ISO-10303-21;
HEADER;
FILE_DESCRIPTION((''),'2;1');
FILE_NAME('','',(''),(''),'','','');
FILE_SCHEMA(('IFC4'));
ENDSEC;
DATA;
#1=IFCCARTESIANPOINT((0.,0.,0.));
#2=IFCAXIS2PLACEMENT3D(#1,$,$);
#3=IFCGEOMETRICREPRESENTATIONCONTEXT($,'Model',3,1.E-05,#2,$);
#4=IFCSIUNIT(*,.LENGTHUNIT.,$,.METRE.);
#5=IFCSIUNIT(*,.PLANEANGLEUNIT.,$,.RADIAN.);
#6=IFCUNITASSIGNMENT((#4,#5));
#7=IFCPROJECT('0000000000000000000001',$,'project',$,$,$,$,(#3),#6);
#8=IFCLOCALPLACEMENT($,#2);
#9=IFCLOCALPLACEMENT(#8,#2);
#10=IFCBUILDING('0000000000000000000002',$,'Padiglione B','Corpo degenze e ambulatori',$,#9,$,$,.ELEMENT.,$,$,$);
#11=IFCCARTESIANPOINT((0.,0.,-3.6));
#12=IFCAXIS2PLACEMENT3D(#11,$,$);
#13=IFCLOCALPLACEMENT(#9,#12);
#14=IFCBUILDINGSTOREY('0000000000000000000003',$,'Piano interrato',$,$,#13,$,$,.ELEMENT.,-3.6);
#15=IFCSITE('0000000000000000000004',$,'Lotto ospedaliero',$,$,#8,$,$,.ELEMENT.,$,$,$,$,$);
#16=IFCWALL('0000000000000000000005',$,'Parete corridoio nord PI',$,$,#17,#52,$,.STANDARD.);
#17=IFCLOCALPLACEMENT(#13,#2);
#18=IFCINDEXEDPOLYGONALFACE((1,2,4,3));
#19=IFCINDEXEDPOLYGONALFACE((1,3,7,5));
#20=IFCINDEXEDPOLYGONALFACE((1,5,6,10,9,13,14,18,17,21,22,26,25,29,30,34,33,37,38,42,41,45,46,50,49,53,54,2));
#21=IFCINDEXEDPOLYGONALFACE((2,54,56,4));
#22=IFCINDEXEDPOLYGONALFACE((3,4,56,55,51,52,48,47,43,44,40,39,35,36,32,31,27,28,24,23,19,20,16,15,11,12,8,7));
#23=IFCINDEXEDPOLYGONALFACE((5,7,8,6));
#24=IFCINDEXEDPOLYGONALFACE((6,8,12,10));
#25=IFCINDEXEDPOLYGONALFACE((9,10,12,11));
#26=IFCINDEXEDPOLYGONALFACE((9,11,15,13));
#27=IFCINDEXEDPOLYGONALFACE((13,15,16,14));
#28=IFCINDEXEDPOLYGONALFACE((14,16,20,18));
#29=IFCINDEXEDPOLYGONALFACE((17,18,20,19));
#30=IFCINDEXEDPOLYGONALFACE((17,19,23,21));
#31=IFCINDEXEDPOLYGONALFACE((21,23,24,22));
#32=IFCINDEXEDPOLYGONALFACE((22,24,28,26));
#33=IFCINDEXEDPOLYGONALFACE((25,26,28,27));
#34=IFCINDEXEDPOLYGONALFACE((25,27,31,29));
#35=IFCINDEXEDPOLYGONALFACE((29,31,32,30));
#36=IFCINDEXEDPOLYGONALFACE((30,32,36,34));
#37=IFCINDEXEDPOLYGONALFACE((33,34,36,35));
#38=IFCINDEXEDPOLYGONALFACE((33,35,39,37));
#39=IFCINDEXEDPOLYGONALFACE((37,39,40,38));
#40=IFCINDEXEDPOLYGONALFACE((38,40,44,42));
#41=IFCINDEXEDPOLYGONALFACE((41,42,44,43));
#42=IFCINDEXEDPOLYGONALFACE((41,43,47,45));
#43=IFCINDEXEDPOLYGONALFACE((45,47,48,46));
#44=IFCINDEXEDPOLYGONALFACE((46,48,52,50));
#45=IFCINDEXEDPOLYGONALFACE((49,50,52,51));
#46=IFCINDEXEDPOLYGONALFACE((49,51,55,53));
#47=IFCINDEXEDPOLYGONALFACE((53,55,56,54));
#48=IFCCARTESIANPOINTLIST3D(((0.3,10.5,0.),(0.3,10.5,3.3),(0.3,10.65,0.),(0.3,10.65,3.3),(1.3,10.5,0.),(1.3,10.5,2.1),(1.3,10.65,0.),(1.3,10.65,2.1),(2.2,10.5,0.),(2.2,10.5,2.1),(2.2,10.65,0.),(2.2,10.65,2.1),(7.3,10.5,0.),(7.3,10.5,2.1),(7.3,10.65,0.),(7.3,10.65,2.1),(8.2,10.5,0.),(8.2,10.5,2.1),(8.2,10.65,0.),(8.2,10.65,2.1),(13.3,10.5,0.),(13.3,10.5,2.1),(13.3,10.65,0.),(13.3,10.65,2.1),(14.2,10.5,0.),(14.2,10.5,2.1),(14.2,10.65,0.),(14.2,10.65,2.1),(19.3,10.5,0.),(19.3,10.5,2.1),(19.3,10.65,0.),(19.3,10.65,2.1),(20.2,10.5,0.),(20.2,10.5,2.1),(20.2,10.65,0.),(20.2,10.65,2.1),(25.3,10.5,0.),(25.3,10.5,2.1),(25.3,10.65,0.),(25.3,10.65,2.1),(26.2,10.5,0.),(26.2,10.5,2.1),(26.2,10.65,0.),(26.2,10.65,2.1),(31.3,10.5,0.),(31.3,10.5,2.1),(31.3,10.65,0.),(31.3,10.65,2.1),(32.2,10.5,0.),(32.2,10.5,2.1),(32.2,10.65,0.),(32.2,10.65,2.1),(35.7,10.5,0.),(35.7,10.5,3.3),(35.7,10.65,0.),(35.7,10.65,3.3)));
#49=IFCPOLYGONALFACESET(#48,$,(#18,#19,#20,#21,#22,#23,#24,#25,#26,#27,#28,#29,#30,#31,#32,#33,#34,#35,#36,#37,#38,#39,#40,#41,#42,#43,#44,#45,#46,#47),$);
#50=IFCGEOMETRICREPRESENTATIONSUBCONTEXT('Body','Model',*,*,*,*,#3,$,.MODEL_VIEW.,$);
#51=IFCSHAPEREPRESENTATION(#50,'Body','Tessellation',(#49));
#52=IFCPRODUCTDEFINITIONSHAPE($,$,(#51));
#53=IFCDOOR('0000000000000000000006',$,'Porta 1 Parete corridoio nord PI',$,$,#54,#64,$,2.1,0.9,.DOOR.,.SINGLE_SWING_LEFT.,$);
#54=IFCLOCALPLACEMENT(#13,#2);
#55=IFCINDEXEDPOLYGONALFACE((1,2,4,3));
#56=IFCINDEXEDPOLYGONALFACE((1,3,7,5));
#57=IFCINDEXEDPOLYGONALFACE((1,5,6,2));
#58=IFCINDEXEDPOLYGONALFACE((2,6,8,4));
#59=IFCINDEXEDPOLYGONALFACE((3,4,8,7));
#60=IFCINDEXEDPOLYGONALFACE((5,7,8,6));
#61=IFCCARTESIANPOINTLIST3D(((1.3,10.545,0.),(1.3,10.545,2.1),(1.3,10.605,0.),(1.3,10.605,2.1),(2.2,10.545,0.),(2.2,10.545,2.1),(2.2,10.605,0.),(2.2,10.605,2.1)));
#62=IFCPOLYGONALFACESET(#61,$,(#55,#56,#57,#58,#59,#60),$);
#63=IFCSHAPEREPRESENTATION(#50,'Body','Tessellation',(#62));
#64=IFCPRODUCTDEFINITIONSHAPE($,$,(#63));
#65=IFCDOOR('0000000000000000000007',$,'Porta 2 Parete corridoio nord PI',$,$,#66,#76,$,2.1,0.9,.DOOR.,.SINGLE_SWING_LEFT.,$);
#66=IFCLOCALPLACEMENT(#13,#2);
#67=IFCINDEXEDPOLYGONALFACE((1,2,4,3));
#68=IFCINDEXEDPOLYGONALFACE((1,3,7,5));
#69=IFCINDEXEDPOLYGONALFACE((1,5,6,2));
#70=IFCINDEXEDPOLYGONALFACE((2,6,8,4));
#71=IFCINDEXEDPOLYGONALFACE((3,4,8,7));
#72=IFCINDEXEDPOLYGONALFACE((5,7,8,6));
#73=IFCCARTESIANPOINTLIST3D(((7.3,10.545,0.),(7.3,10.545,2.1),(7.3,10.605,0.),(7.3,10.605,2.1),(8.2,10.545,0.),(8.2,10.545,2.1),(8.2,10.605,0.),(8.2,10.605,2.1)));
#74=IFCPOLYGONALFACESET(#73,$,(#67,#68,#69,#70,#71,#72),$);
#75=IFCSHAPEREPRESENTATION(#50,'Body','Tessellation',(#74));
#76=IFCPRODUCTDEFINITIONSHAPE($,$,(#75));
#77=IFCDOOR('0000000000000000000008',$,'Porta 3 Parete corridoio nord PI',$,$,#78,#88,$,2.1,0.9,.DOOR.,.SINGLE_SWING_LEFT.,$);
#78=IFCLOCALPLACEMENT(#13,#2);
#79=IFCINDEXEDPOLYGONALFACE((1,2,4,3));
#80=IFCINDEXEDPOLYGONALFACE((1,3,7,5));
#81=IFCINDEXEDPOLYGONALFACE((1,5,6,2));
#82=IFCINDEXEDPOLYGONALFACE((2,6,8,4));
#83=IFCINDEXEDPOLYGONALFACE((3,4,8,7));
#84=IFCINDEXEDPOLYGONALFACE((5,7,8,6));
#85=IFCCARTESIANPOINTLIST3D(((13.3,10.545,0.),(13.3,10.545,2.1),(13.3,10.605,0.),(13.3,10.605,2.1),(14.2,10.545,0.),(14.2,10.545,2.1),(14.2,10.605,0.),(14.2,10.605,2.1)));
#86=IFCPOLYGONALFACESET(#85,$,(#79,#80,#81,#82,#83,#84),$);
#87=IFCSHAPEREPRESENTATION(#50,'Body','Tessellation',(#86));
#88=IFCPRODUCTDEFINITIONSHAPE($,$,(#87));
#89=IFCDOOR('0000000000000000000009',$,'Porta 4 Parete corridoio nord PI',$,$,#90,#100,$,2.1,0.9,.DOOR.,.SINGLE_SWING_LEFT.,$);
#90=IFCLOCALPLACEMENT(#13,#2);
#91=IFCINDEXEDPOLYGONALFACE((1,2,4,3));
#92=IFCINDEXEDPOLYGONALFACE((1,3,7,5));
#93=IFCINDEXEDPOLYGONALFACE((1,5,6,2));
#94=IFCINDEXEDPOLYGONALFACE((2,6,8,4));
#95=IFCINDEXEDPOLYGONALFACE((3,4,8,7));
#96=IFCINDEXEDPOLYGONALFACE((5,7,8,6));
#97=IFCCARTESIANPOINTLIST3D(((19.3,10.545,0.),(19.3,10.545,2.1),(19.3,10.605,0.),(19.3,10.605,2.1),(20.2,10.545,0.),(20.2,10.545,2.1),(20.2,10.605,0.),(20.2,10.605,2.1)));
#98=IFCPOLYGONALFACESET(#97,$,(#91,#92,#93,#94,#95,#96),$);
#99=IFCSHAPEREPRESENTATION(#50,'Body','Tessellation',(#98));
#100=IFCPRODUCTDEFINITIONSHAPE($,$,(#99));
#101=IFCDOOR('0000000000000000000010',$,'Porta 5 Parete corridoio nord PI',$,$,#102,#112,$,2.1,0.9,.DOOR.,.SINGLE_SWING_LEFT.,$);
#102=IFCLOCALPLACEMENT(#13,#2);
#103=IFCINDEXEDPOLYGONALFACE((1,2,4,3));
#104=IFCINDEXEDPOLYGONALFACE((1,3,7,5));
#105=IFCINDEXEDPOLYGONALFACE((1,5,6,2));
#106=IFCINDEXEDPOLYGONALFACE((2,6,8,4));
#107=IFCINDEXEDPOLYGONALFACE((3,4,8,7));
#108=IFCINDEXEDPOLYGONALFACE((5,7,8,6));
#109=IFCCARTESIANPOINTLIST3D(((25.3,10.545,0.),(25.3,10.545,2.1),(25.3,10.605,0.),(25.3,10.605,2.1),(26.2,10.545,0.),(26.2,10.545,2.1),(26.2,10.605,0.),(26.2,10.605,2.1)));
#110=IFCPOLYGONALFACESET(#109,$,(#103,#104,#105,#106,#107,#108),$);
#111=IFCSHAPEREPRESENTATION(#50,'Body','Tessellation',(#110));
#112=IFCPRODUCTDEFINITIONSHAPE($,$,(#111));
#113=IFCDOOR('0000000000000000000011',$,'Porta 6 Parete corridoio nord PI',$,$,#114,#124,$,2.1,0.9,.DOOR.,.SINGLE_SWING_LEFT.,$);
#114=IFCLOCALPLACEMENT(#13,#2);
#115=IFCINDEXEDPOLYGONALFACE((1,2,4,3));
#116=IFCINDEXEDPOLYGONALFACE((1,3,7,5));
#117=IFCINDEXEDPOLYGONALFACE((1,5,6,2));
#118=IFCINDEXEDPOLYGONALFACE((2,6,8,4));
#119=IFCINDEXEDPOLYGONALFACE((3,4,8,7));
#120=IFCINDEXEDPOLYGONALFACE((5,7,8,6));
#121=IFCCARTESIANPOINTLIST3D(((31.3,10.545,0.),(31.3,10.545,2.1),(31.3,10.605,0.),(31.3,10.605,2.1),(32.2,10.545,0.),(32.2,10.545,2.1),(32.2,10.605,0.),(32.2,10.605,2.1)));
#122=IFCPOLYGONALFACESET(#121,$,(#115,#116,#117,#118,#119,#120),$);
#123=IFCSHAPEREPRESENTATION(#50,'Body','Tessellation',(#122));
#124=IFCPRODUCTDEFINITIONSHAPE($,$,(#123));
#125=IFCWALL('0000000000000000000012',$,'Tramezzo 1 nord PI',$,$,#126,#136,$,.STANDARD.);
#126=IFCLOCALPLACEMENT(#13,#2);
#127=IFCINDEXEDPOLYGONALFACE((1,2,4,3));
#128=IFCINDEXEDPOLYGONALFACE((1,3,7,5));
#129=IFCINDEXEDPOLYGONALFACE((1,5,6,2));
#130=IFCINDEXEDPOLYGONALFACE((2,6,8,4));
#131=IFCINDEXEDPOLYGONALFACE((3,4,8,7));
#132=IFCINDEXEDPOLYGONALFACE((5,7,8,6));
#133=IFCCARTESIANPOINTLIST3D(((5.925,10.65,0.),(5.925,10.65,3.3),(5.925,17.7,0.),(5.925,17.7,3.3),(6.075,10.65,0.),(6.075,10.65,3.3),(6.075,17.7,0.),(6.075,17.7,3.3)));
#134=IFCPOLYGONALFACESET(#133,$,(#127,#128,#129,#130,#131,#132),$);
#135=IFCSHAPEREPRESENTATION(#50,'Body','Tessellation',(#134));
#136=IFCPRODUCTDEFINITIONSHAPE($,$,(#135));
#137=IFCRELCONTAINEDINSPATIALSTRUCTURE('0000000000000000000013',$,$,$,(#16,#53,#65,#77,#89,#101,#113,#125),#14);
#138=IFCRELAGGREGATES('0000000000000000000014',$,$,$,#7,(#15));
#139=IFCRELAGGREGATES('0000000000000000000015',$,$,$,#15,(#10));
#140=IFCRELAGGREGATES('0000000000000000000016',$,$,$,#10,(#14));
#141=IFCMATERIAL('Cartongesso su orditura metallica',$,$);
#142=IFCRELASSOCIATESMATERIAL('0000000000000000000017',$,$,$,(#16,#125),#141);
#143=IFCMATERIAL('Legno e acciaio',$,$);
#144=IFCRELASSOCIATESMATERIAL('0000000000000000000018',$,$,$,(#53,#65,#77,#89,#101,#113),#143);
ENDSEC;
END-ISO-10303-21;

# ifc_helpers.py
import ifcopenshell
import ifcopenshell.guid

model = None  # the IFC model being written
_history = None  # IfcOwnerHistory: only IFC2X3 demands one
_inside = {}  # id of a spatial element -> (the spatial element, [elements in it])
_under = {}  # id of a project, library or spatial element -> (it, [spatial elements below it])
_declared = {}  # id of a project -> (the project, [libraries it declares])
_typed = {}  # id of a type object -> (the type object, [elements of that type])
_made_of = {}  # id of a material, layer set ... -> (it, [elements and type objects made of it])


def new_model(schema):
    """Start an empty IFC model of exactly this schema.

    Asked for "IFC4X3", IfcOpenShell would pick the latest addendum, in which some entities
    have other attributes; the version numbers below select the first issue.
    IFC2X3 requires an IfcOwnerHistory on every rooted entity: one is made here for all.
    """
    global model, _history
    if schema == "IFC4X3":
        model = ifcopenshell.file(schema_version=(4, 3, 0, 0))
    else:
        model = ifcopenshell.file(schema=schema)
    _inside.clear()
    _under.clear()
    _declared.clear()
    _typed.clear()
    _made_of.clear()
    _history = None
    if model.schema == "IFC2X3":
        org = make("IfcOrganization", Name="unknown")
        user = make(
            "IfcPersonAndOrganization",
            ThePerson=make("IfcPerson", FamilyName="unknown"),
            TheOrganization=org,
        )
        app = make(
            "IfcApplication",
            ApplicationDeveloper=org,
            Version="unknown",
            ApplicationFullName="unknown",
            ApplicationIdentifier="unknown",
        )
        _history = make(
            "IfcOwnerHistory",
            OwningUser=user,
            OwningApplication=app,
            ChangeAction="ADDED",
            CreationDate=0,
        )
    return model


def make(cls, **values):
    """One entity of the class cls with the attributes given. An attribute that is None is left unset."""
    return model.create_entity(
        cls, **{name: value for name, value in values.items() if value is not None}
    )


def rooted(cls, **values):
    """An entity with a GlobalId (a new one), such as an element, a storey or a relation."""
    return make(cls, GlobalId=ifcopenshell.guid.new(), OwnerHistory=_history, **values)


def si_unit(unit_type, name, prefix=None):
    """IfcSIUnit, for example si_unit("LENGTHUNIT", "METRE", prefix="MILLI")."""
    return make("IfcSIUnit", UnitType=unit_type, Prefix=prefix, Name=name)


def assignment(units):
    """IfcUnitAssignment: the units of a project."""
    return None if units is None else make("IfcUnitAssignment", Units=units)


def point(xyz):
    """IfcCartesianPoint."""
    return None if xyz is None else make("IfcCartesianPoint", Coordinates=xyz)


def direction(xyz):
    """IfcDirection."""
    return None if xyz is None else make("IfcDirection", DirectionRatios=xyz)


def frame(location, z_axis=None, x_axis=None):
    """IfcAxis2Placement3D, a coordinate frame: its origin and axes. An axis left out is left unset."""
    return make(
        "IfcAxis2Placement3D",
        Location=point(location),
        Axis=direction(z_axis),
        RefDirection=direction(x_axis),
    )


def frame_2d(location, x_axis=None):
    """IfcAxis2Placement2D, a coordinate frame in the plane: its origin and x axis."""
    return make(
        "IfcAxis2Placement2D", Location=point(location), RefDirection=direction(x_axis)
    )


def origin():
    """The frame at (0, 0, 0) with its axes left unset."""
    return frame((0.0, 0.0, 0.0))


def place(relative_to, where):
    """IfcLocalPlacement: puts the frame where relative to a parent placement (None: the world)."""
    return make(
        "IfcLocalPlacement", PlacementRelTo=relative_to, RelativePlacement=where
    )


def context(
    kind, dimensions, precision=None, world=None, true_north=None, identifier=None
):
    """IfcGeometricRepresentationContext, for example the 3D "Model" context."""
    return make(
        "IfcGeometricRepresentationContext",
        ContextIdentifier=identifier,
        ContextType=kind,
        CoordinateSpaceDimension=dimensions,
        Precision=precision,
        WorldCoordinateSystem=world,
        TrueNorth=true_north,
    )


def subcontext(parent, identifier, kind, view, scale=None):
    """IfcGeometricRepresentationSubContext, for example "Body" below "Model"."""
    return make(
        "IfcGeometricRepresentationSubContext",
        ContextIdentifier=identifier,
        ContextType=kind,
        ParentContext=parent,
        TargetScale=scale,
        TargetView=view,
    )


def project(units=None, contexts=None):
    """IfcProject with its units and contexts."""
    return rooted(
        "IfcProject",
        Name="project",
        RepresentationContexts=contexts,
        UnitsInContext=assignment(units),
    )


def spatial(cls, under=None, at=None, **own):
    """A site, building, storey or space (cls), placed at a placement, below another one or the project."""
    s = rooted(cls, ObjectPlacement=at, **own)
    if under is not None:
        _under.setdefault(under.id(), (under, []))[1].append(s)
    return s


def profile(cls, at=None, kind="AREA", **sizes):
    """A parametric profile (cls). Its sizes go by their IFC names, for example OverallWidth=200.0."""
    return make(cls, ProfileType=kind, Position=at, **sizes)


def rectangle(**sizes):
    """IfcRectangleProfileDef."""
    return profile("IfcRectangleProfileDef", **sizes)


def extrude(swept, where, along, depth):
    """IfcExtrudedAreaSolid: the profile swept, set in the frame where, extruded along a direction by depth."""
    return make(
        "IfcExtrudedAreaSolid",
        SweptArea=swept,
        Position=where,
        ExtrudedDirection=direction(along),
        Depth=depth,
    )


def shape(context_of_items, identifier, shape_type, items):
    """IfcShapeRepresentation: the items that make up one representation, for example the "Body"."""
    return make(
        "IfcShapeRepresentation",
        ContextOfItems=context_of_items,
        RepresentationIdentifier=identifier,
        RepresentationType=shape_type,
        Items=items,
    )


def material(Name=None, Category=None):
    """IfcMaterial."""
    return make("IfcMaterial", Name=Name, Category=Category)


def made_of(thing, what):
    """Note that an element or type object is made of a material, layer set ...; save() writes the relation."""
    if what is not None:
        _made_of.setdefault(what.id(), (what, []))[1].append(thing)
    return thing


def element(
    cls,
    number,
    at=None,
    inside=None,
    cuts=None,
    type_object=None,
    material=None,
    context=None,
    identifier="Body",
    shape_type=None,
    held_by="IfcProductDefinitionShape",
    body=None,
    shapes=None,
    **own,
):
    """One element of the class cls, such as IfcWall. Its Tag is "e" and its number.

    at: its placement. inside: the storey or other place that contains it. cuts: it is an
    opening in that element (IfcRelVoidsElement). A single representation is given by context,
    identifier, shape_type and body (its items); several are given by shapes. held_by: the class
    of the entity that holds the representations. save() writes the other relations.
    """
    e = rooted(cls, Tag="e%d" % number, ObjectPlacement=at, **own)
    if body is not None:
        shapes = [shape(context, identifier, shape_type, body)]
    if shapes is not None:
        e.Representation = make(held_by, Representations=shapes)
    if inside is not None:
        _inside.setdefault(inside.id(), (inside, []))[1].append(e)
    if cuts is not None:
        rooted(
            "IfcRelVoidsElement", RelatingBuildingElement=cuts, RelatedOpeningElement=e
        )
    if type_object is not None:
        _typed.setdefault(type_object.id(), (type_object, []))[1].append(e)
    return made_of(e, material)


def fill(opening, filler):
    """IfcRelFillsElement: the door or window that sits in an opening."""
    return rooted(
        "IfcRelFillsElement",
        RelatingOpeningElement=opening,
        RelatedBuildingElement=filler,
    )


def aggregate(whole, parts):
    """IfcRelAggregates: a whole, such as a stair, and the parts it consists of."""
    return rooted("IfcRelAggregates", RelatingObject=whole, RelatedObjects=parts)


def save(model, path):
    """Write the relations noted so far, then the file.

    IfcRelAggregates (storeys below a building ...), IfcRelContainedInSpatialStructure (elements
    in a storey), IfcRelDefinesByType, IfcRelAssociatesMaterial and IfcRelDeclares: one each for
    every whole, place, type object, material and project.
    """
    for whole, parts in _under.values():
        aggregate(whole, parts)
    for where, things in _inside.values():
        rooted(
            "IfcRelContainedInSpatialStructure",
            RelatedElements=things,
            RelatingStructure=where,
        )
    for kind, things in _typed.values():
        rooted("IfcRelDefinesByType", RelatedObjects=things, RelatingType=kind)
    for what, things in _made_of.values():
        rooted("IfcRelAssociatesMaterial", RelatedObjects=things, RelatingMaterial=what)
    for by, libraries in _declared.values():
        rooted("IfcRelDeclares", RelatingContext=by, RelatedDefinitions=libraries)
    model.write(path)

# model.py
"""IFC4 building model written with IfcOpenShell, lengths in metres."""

from ifc_helpers import new_model, si_unit, frame, frame_2d, origin, place, context, subcontext, project, spatial, rectangle, extrude, material, element, fill, save


model = new_model("IFC4")

# Units and contexts
model_context = context("Model", 3, precision=1e-05, world=origin())
body_context = subcontext(model_context, "Body", "Model", "MODEL_VIEW")
ifc_project = project(units=[si_unit("LENGTHUNIT", "METRE"), si_unit("PLANEANGLEUNIT", "RADIAN")], contexts=[model_context])

# Site, building, storey
site_placement = place(None, origin())
site = spatial("IfcSite", under=ifc_project, at=site_placement, Name="Lotto ospedaliero", CompositionType="ELEMENT")
building_placement = place(site_placement, origin())
building = spatial("IfcBuilding", under=site, at=building_placement, Name="Padiglione B", Description="Corpo degenze e ambulatori", CompositionType="ELEMENT")
storey_placement = place(building_placement, frame((0.0, 0.0, -3.6)))
storey = spatial("IfcBuildingStorey", under=building, at=storey_placement, Name="Piano interrato", CompositionType="ELEMENT", Elevation=-3.6)

# Wall, openings, doors
ifc_material_1 = material(Name="Cartongesso su orditura metallica")
ifc_material_2 = material(Name="Legno e acciaio")
wall_1_placement = place(storey_placement, frame((0.3, 10.5, 0.0)))
wall_1 = element("IfcWall", 1, at=wall_1_placement, inside=storey, material=ifc_material_1, Name="Parete corridoio nord PI", PredefinedType="STANDARD", context=body_context, shape_type="SweptSolid", body=[
    extrude(rectangle(XDim=35.4, YDim=0.15, at=frame_2d((17.7, 0.075))), origin(), (0.0, 0.0, 1.0), 3.3),
])
opening_1_placement = place(wall_1_placement, frame((1.0, -0.1, 0.0)))
opening_1 = element("IfcOpeningElement", 2, at=opening_1_placement, cuts=wall_1, PredefinedType="OPENING", context=body_context, shape_type="SweptSolid", body=[
    extrude(rectangle(XDim=0.9, YDim=0.35, at=frame_2d((0.45, 0.175))), origin(), (0.0, 0.0, 1.0), 2.1),
])
opening_2_placement = place(wall_1_placement, frame((7.0, -0.1, 0.0)))
opening_2 = element("IfcOpeningElement", 3, at=opening_2_placement, cuts=wall_1, PredefinedType="OPENING", context=body_context, shape_type="SweptSolid", body=[
    extrude(rectangle(XDim=0.9, YDim=0.35, at=frame_2d((0.45, 0.175))), origin(), (0.0, 0.0, 1.0), 2.1),
])
opening_3_placement = place(wall_1_placement, frame((13.0, -0.1, 0.0)))
opening_3 = element("IfcOpeningElement", 4, at=opening_3_placement, cuts=wall_1, PredefinedType="OPENING", context=body_context, shape_type="SweptSolid", body=[
    extrude(rectangle(XDim=0.9, YDim=0.35, at=frame_2d((0.45, 0.175))), origin(), (0.0, 0.0, 1.0), 2.1),
])
opening_4_placement = place(wall_1_placement, frame((19.0, -0.1, 0.0)))
opening_4 = element("IfcOpeningElement", 5, at=opening_4_placement, cuts=wall_1, PredefinedType="OPENING", context=body_context, shape_type="SweptSolid", body=[
    extrude(rectangle(XDim=0.9, YDim=0.35, at=frame_2d((0.45, 0.175))), origin(), (0.0, 0.0, 1.0), 2.1),
])
opening_5_placement = place(wall_1_placement, frame((25.0, -0.1, 0.0)))
opening_5 = element("IfcOpeningElement", 6, at=opening_5_placement, cuts=wall_1, PredefinedType="OPENING", context=body_context, shape_type="SweptSolid", body=[
    extrude(rectangle(XDim=0.9, YDim=0.35, at=frame_2d((0.45, 0.175))), origin(), (0.0, 0.0, 1.0), 2.1),
])
opening_6_placement = place(wall_1_placement, frame((31.0, -0.1, 0.0)))
opening_6 = element("IfcOpeningElement", 7, at=opening_6_placement, cuts=wall_1, PredefinedType="OPENING", context=body_context, shape_type="SweptSolid", body=[
    extrude(rectangle(XDim=0.9, YDim=0.35, at=frame_2d((0.45, 0.175))), origin(), (0.0, 0.0, 1.0), 2.1),
])
door_1_placement = place(wall_1_placement, frame((1.0, 0.045, 0.0)))
door_1 = element("IfcDoor", 8, at=door_1_placement, inside=storey, material=ifc_material_2, Name="Porta 1 Parete corridoio nord PI", OperationType="SINGLE_SWING_LEFT", OverallHeight=2.1, OverallWidth=0.9, PredefinedType="DOOR", context=body_context, shape_type="SweptSolid", body=[
    extrude(rectangle(XDim=0.9, YDim=0.06, at=frame_2d((0.45, 0.03))), origin(), (0.0, 0.0, 1.0), 2.1),
])
fill(opening_1, door_1)
door_2_placement = place(wall_1_placement, frame((7.0, 0.045, 0.0)))
door_2 = element("IfcDoor", 9, at=door_2_placement, inside=storey, material=ifc_material_2, Name="Porta 2 Parete corridoio nord PI", OperationType="SINGLE_SWING_LEFT", OverallHeight=2.1, OverallWidth=0.9, PredefinedType="DOOR", context=body_context, shape_type="SweptSolid", body=[
    extrude(rectangle(XDim=0.9, YDim=0.06, at=frame_2d((0.45, 0.03))), origin(), (0.0, 0.0, 1.0), 2.1),
])
fill(opening_2, door_2)
door_3_placement = place(wall_1_placement, frame((13.0, 0.045, 0.0)))
door_3 = element("IfcDoor", 10, at=door_3_placement, inside=storey, material=ifc_material_2, Name="Porta 3 Parete corridoio nord PI", OperationType="SINGLE_SWING_LEFT", OverallHeight=2.1, OverallWidth=0.9, PredefinedType="DOOR", context=body_context, shape_type="SweptSolid", body=[
    extrude(rectangle(XDim=0.9, YDim=0.06, at=frame_2d((0.45, 0.03))), origin(), (0.0, 0.0, 1.0), 2.1),
])
fill(opening_3, door_3)
door_4_placement = place(wall_1_placement, frame((19.0, 0.045, 0.0)))
door_4 = element("IfcDoor", 11, at=door_4_placement, inside=storey, material=ifc_material_2, Name="Porta 4 Parete corridoio nord PI", OperationType="SINGLE_SWING_LEFT", OverallHeight=2.1, OverallWidth=0.9, PredefinedType="DOOR", context=body_context, shape_type="SweptSolid", body=[
    extrude(rectangle(XDim=0.9, YDim=0.06, at=frame_2d((0.45, 0.03))), origin(), (0.0, 0.0, 1.0), 2.1),
])
fill(opening_4, door_4)
door_5_placement = place(wall_1_placement, frame((25.0, 0.045, 0.0)))
door_5 = element("IfcDoor", 12, at=door_5_placement, inside=storey, material=ifc_material_2, Name="Porta 5 Parete corridoio nord PI", OperationType="SINGLE_SWING_LEFT", OverallHeight=2.1, OverallWidth=0.9, PredefinedType="DOOR", context=body_context, shape_type="SweptSolid", body=[
    extrude(rectangle(XDim=0.9, YDim=0.06, at=frame_2d((0.45, 0.03))), origin(), (0.0, 0.0, 1.0), 2.1),
])
fill(opening_5, door_5)
door_6_placement = place(wall_1_placement, frame((31.0, 0.045, 0.0)))
door_6 = element("IfcDoor", 13, at=door_6_placement, inside=storey, material=ifc_material_2, Name="Porta 6 Parete corridoio nord PI", OperationType="SINGLE_SWING_LEFT", OverallHeight=2.1, OverallWidth=0.9, PredefinedType="DOOR", context=body_context, shape_type="SweptSolid", body=[
    extrude(rectangle(XDim=0.9, YDim=0.06, at=frame_2d((0.45, 0.03))), origin(), (0.0, 0.0, 1.0), 2.1),
])
fill(opening_6, door_6)

# Wall
wall_2_placement = place(storey_placement, frame((5.925, 10.65, 0.0)))
element("IfcWall", 14, at=wall_2_placement, inside=storey, material=ifc_material_1, Name="Tramezzo 1 nord PI", PredefinedType="STANDARD", context=body_context, shape_type="SweptSolid", body=[
    extrude(rectangle(XDim=0.15, YDim=7.05, at=frame_2d((0.075, 3.525))), origin(), (0.0, 0.0, 1.0), 3.3),
])

save(model, "model.ifc")
